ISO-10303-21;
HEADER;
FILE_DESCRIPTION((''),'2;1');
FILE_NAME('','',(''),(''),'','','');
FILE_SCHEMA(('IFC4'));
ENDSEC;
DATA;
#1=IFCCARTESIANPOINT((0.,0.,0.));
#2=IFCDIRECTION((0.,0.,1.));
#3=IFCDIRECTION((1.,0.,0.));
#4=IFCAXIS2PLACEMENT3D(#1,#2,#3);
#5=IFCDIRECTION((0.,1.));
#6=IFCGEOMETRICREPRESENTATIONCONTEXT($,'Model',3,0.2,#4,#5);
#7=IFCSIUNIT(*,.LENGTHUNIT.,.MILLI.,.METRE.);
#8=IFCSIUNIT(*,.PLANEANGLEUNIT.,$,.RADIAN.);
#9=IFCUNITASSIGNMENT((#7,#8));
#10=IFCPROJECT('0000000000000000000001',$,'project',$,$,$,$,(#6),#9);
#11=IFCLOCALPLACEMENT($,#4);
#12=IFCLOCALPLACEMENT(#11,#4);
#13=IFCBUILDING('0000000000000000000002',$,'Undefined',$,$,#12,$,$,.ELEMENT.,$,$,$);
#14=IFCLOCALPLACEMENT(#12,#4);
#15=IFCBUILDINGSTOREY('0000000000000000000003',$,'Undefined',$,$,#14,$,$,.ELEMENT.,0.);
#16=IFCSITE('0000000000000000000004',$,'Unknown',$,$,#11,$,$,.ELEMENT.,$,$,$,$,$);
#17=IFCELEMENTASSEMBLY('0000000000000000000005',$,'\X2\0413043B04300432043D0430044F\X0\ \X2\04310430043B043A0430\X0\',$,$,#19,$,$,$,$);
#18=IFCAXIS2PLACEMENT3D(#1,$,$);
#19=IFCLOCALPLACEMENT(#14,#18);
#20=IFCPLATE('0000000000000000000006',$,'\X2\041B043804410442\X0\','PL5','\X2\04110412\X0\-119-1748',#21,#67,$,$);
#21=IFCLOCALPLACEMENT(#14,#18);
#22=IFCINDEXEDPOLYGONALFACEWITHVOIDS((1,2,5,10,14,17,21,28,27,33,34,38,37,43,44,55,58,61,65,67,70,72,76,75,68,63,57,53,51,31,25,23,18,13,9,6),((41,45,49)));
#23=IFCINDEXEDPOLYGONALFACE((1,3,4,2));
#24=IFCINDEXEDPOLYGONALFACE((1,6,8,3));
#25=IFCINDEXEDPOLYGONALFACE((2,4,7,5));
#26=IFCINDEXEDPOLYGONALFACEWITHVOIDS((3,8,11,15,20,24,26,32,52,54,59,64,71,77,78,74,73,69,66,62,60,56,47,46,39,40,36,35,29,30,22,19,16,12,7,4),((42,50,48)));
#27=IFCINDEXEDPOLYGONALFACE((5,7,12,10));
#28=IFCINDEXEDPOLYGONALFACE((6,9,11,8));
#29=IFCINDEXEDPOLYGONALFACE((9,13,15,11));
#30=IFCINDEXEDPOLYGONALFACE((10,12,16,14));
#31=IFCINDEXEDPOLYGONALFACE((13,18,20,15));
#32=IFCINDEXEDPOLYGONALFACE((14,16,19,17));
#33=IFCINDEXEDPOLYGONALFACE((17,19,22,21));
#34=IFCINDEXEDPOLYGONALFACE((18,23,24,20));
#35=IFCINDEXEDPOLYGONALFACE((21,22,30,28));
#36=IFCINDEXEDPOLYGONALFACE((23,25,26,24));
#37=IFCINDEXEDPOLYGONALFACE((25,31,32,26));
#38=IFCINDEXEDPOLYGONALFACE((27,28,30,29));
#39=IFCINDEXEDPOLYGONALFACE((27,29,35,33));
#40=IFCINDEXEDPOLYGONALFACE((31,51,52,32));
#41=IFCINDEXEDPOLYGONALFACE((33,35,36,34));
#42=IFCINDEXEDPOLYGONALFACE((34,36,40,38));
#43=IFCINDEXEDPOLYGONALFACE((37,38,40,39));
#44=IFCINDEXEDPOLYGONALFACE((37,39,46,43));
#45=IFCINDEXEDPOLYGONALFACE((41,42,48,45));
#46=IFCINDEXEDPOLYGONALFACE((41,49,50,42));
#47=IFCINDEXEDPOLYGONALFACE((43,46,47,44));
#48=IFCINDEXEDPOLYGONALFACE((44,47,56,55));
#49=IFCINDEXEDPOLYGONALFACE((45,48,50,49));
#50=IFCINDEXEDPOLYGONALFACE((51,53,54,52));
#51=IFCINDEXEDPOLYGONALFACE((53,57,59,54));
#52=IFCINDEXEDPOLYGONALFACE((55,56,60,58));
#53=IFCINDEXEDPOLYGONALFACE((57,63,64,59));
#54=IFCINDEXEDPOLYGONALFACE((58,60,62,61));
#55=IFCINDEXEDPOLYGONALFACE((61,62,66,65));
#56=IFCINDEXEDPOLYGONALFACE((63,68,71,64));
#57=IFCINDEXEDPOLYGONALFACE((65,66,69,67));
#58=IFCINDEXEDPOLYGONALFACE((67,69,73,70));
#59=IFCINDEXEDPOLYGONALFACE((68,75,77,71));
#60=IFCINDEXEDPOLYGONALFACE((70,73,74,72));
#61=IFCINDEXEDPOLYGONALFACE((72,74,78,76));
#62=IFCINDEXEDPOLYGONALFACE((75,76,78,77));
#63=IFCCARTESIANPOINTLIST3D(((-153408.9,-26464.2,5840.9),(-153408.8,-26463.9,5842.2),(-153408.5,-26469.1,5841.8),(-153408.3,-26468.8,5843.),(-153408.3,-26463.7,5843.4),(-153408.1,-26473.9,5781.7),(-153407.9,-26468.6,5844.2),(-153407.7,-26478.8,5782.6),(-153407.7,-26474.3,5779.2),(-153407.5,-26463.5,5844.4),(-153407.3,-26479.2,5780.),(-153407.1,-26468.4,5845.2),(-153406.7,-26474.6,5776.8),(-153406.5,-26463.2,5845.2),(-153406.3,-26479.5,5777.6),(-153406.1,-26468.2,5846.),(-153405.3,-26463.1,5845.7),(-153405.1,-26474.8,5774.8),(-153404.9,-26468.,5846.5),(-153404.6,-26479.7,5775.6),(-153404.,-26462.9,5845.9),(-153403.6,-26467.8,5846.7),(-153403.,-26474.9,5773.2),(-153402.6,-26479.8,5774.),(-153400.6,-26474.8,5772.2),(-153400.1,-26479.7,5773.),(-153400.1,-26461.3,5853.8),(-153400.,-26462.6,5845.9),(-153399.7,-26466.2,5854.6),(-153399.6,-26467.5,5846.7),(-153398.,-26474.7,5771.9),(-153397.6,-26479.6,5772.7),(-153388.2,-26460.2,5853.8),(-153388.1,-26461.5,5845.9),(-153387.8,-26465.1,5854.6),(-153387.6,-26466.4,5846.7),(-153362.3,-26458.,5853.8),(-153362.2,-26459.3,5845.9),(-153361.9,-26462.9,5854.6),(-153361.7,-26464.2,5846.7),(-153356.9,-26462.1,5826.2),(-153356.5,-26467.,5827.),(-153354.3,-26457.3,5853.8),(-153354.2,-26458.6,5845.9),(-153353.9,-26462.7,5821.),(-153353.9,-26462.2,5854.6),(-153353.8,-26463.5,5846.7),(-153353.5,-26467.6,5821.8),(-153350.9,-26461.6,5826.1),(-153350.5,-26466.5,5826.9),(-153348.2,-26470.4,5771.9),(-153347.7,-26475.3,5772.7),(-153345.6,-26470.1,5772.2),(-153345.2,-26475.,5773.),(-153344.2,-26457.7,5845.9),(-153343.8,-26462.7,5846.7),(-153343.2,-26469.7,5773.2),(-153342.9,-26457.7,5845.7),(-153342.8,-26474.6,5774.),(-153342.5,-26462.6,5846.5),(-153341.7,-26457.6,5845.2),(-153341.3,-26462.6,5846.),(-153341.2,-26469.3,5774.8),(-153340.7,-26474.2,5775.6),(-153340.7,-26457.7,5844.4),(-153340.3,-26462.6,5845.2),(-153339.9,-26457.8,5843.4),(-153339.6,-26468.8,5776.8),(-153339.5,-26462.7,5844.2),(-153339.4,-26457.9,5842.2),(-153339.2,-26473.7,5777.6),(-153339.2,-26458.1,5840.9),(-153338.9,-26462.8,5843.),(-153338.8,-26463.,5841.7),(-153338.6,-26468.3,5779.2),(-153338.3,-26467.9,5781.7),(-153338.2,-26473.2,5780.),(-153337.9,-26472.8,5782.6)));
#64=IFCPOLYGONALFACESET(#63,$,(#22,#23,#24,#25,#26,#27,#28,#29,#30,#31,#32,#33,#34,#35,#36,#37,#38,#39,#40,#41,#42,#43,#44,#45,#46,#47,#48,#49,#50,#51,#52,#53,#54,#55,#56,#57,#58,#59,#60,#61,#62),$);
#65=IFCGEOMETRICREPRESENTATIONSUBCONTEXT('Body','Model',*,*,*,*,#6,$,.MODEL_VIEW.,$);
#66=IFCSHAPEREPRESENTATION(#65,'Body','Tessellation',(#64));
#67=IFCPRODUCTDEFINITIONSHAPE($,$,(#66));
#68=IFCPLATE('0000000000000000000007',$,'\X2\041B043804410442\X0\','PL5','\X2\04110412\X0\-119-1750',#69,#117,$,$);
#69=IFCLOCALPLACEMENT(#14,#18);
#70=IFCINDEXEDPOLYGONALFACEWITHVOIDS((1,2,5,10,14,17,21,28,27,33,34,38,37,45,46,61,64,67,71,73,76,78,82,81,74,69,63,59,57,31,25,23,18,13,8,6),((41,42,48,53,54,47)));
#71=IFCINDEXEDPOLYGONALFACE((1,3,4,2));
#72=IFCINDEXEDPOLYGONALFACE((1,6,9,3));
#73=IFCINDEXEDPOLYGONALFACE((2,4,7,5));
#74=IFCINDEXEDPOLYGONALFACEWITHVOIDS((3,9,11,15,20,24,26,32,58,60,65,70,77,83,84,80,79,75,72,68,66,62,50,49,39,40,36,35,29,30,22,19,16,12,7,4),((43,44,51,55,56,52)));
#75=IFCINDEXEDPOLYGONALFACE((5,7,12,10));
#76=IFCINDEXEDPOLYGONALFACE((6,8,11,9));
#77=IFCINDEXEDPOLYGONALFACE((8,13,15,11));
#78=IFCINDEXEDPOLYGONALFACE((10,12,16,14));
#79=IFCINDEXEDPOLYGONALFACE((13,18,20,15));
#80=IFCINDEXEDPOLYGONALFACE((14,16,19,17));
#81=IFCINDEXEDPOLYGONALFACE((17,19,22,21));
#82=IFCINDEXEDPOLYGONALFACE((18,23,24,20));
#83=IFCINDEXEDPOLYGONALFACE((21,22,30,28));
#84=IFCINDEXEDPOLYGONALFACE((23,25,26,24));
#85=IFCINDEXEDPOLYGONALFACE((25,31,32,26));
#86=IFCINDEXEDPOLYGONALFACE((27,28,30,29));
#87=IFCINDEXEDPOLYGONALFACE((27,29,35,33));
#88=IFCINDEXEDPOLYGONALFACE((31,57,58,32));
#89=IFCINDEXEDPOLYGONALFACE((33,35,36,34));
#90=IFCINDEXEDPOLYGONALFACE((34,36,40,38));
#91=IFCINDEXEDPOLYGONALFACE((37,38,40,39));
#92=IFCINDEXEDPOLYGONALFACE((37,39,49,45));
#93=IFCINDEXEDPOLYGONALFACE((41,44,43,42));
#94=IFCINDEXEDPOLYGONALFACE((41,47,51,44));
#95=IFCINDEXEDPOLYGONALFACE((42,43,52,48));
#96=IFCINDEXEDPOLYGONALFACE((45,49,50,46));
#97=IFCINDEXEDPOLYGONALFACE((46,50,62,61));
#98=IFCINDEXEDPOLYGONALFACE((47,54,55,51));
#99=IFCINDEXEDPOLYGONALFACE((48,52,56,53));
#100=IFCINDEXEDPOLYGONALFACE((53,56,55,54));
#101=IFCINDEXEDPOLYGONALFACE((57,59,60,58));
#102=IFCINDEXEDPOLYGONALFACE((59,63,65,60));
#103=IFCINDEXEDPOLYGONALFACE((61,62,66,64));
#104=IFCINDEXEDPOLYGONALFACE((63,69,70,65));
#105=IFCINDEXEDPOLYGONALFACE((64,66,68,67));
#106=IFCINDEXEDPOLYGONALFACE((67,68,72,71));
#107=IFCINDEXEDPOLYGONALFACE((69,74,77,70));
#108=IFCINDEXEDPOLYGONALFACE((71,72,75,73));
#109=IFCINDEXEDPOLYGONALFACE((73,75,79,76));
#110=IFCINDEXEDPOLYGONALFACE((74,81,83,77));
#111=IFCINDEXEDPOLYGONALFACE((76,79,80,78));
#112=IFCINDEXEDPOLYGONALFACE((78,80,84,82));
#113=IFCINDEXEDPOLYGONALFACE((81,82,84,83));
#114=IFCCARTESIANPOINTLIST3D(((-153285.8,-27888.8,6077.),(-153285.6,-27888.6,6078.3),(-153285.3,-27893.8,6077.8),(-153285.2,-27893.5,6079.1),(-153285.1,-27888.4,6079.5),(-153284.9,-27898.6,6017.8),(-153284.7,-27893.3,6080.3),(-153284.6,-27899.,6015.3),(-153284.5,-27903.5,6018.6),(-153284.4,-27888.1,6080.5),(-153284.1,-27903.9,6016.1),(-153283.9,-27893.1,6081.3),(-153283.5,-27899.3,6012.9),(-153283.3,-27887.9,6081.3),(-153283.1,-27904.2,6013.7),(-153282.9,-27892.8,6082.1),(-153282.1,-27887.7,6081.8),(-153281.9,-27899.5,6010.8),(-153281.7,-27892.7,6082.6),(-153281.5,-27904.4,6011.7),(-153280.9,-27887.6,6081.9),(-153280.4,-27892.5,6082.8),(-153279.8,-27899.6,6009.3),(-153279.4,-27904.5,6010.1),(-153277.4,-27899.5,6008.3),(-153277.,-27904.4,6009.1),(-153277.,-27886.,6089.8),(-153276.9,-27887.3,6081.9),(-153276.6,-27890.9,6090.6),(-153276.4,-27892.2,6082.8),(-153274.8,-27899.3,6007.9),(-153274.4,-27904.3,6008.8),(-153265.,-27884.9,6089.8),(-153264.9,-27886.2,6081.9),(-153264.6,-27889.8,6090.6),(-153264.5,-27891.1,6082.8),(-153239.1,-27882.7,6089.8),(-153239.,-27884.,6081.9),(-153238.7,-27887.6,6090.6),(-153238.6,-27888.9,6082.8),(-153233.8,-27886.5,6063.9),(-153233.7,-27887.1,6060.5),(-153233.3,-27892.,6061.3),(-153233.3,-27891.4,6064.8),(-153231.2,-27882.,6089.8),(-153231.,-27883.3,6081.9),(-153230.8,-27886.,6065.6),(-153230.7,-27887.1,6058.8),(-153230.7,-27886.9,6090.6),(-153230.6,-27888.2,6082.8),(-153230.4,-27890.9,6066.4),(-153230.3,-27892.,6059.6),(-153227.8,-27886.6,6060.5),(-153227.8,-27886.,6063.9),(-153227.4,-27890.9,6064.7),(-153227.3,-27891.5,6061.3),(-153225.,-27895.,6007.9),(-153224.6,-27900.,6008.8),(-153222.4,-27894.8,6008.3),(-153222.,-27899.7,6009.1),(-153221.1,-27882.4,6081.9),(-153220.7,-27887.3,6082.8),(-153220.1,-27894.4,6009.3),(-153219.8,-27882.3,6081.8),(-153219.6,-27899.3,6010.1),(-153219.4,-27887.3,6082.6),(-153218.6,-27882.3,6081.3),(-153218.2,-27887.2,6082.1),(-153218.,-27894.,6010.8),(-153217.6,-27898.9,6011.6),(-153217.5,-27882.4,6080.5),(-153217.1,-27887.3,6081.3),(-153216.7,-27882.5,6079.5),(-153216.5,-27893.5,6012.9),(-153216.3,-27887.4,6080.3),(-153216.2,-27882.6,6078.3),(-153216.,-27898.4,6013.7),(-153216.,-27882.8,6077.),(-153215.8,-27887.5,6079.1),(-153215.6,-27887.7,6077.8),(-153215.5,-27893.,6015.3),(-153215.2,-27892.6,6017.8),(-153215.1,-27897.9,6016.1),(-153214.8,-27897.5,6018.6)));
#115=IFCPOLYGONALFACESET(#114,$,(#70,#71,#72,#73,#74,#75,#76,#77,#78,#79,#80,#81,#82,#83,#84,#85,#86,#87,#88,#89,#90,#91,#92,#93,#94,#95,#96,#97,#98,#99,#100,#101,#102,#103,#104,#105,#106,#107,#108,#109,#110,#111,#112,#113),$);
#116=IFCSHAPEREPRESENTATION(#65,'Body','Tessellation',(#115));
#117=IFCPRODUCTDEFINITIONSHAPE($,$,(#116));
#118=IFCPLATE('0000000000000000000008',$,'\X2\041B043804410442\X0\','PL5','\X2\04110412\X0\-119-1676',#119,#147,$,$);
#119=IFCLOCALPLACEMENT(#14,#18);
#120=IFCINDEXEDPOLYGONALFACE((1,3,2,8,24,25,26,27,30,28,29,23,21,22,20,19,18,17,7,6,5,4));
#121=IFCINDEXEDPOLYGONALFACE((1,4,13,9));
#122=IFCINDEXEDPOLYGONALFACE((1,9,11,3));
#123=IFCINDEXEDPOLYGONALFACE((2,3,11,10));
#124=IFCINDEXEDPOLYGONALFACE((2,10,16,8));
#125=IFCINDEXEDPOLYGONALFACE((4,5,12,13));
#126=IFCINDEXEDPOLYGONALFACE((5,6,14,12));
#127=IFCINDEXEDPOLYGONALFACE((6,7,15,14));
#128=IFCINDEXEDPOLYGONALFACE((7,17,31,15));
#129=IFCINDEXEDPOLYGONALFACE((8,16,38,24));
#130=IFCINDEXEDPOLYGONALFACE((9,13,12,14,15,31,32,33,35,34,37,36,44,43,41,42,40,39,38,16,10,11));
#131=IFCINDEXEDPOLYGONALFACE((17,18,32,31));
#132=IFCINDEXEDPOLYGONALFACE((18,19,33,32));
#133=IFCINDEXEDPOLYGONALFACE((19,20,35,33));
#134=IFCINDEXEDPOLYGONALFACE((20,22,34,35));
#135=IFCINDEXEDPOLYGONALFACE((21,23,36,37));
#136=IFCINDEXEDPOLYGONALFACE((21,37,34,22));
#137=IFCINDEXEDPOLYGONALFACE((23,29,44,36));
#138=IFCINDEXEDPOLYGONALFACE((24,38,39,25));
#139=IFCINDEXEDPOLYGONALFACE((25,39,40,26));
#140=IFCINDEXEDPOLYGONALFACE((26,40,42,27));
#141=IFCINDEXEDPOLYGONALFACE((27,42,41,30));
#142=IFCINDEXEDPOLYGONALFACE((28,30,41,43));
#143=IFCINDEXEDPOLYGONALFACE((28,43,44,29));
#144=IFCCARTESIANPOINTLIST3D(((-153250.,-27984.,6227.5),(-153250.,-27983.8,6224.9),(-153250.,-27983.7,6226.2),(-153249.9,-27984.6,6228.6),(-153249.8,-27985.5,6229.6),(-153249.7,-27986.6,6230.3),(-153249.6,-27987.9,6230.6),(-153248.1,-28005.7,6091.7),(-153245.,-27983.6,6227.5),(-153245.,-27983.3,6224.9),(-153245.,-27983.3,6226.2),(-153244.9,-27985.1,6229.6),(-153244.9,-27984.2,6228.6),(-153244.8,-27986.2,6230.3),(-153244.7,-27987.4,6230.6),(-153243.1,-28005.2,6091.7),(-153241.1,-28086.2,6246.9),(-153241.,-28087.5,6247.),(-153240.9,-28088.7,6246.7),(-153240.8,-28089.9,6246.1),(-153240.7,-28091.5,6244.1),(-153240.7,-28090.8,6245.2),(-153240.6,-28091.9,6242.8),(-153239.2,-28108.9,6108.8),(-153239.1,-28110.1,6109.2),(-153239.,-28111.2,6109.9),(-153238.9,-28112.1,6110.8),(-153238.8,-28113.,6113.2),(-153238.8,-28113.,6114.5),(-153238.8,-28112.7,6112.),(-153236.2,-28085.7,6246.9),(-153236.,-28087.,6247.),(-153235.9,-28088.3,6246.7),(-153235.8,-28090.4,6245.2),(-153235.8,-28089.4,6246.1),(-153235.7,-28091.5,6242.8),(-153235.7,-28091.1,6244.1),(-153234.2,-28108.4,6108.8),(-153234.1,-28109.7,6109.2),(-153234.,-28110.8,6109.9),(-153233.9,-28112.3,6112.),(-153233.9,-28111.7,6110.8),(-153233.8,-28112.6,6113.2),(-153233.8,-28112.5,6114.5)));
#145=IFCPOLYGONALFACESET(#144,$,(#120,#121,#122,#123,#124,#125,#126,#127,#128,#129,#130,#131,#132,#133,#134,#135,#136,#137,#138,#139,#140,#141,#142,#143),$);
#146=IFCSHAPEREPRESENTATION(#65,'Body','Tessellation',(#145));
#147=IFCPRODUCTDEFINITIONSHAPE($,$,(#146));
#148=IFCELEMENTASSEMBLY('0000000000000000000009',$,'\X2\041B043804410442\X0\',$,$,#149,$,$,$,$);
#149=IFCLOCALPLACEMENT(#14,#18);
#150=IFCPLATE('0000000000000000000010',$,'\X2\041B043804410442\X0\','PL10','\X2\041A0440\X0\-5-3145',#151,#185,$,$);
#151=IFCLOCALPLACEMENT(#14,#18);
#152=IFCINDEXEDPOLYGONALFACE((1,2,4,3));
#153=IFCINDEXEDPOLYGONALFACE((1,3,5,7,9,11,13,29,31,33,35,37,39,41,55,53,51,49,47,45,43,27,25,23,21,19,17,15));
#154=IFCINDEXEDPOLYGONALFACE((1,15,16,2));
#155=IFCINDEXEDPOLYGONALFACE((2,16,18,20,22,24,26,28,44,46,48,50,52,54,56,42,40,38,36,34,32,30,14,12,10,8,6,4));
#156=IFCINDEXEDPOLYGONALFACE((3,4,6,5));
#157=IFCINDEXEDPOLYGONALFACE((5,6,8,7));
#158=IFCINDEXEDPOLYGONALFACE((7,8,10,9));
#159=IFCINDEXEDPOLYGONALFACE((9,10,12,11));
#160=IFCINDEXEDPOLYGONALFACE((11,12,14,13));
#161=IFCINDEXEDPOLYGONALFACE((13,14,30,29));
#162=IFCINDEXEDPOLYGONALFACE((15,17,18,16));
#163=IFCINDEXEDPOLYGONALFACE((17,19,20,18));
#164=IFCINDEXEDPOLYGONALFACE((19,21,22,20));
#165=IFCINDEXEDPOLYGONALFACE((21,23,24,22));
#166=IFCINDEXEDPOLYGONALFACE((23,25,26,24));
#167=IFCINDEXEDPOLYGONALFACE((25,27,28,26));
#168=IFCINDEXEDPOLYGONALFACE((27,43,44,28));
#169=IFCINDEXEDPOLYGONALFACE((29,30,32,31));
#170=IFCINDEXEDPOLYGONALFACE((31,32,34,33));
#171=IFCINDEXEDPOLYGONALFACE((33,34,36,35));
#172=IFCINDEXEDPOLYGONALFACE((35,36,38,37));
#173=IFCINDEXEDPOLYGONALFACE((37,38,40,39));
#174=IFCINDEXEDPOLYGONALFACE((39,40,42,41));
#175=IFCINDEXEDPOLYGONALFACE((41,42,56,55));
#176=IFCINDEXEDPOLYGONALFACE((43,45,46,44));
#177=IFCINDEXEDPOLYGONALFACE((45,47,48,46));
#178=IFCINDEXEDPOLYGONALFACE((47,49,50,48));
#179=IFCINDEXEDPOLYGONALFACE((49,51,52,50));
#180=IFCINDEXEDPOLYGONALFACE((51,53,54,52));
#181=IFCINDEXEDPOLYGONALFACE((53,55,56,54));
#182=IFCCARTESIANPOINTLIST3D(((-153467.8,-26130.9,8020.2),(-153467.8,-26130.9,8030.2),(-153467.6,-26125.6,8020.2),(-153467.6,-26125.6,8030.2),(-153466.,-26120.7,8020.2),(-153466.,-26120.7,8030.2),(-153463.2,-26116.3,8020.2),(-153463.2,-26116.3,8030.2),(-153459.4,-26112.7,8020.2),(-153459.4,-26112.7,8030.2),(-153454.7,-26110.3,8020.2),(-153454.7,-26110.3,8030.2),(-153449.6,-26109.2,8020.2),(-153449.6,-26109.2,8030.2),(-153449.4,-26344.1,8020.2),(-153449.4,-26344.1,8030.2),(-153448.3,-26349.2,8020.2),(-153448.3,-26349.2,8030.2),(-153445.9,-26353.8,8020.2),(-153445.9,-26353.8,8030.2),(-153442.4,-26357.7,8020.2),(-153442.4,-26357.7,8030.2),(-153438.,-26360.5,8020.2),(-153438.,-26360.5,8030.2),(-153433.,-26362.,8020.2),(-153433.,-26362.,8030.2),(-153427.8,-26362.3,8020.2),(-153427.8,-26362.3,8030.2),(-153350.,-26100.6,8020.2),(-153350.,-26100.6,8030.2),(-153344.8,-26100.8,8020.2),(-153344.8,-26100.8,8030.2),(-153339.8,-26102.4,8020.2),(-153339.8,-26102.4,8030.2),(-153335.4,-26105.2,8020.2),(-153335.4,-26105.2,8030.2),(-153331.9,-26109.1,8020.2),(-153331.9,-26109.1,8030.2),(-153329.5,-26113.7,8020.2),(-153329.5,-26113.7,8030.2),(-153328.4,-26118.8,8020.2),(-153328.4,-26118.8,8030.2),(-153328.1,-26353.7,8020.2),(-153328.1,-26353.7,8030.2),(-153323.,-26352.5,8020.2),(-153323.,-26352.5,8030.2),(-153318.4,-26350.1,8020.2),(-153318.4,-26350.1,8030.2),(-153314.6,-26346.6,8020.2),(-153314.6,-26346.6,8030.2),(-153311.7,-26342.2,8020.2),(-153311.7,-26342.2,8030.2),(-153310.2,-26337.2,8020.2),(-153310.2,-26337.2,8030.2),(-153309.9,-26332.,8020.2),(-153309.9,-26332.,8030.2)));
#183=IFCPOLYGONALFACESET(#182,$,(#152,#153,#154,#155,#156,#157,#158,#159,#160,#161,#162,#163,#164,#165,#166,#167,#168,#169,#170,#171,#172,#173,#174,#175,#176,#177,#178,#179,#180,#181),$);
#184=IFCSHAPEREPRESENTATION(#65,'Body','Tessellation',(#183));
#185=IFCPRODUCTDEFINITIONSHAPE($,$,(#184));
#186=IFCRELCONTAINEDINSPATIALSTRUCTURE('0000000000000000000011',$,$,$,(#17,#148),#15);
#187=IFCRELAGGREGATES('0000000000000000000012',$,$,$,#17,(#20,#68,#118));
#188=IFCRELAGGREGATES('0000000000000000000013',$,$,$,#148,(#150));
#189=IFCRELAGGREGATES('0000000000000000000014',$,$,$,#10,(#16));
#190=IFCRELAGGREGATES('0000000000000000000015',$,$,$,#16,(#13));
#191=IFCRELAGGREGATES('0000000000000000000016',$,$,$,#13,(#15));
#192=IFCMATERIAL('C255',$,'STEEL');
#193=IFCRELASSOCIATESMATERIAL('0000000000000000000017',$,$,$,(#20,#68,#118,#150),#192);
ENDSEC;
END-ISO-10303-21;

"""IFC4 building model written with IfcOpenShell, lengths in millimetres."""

from ifc_helpers import new_model, si_unit, direction, frame, origin_with_axes, place, context, subcontext, project, spatial, line, arc, indexed_curve, outline, extrude, material, element, aggregate, save


model = new_model("IFC4")

# Units and contexts
model_context = context("Model", 3, precision=0.2, world=origin_with_axes(), true_north=direction((0.0, 1.0)))
body_context = subcontext(model_context, "Body", "Model", "MODEL_VIEW")
ifc_project = project(units=[si_unit("LENGTHUNIT", "METRE", prefix="MILLI"), si_unit("PLANEANGLEUNIT", "RADIAN")], contexts=[model_context])

# Site, building, storey
site_placement = place(None, origin_with_axes())
site = spatial("IfcSite", under=ifc_project, at=site_placement, Name="Unknown", CompositionType="ELEMENT")
building_placement = place(site_placement, origin_with_axes())
building = spatial("IfcBuilding", under=site, at=building_placement, Name="Undefined", CompositionType="ELEMENT")
storey_placement = place(building_placement, origin_with_axes())
storey = spatial("IfcBuildingStorey", under=building, at=storey_placement, Name="Undefined", CompositionType="ELEMENT", Elevation=0.0)

# Shared definitions
ifc_material_1 = material(Name="C255", Category="STEEL")

# Element assembly, plates, voiding features
assembly_1_placement = place(storey_placement, frame((-153404.6, -26166.6, 5857.9), z_axis=(-0.996285, -0.086114, 0.000024), x_axis=(0.084961, -0.982981, 0.162881)))
assembly_1 = element("IfcElementAssembly", 1, at=assembly_1_placement, inside=storey, Name="Главная балка")
plate_1_placement = place(assembly_1_placement, frame((291.8, -135.0, -40.0), z_axis=(-1.0, -0.000054, 0.0), x_axis=(0.0, 0.000054, 1.0)))
plate_1 = element("IfcPlate", 2, at=plate_1_placement, material=ifc_material_1, Name="Лист", Description="PL5", ObjectType="БВ-119-1748", context=body_context, shape_type="SolidModel", body=[
    extrude(outline(indexed_curve([(0.0, 10.0), (2.9, 2.9), (10.0, 0.0), (60.0, 0.0), (67.1, 2.9), (70.0, 10.0), (70.0, 70.0), (68.5, 73.5), (65.0, 75.0), (61.0, 75.0), (61.0, 83.0), (49.0, 83.0), (49.0, 75.0), (23.0, 75.0), (23.0, 83.0), (15.0, 83.0), (15.0, 75.0), (5.0, 75.0), (1.5, 73.5), (0.0, 70.0)], segments=[arc(1, 2, 3), line(3, 4), arc(4, 5, 6), line(6, 7), arc(7, 8, 9), line(9, 10, 11, 12, 13, 14, 15, 16, 17, 18), arc(18, 19, 20), line(20, 1)])), frame((0.0, 0.0, 2.5), z_axis=(0.0, 0.0, 1.0), x_axis=(1.0, 0.0, 0.0)), (0.0, 0.0, -1.0), 5.0),
])
voiding_feature_1_placement = place(plate_1_placement, frame((15.0, 55.0, 10.0), z_axis=(0.007997, -0.999968, -0.000026), x_axis=(0.0, 0.000026, -1.0)))
element("IfcVoidingFeature", 3, at=voiding_feature_1_placement, cuts=plate_1, Name="Балка", ObjectType="(?)", PredefinedType="HOLE", context=body_context, shape_type="SolidModel", body=[
    extrude(outline(indexed_curve([(0.0, -3.0), (5.2, 0.0), (0.0, 3.0)], segments=[line(1, 2, 3, 1)])), frame((0.0, 0.0, 0.0), z_axis=(-1.0, 0.0, 0.0), x_axis=(0.0, 0.0, 1.0)), (0.0, 0.0, -1.0), 20.0),
])
plate_2_placement = place(assembly_1_placement, frame((1741.2, -135.0, -40.0), z_axis=(-1.0, -0.000054, 0.0), x_axis=(0.0, 0.000054, 1.0)))
plate_2 = element("IfcPlate", 4, at=plate_2_placement, material=ifc_material_1, Name="Лист", Description="PL5", ObjectType="БВ-119-1750", context=body_context, shape_type="SolidModel", body=[
    extrude(outline(indexed_curve([(0.0, 10.0), (2.9, 2.9), (10.0, 0.0), (60.0, 0.0), (67.1, 2.9), (70.0, 10.0), (70.0, 70.0), (68.5, 73.5), (65.0, 75.0), (61.0, 75.0), (61.0, 83.0), (49.0, 83.0), (49.0, 75.0), (23.0, 75.0), (23.0, 83.0), (15.0, 83.0), (15.0, 75.0), (5.0, 75.0), (1.5, 73.5), (0.0, 70.0)], segments=[arc(1, 2, 3), line(3, 4), arc(4, 5, 6), line(6, 7), arc(7, 8, 9), line(9, 10, 11, 12, 13, 14, 15, 16, 17, 18), arc(18, 19, 20), line(20, 1)])), frame((0.0, 0.0, 2.5), z_axis=(0.0, 0.0, 1.0), x_axis=(1.0, 0.0, 0.0)), (0.0, 0.0, -1.0), 5.0),
])
voiding_feature_2_placement = place(plate_2_placement, frame((15.0, 55.0, 10.0), z_axis=(0.007997, -0.999968, -0.000026), x_axis=(0.0, 0.000026, -1.0)))
element("IfcVoidingFeature", 5, at=voiding_feature_2_placement, cuts=plate_2, Name="Балка", ObjectType="(?)", PredefinedType="HOLE", context=body_context, shape_type="SolidModel", body=[
    extrude(outline(indexed_curve([(1.7, -3.0), (3.5, 0.0), (1.7, 3.0), (-1.7, 3.0), (-3.5, 0.0), (-1.7, -3.0)], segments=[line(1, 2, 3, 4, 5, 6, 1)])), frame((0.0, 0.0, 0.0), z_axis=(-1.0, 0.0, 0.0), x_axis=(0.0, 0.0, 1.0)), (0.0, 0.0, -1.0), 20.0),
])
plate_3_placement = place(assembly_1_placement, frame((1969.1, 70.0, 0.0), z_axis=(0.0, 0.0, -1.0), x_axis=(0.0, -1.0, 0.0)))
plate_3 = element("IfcPlate", 6, at=plate_3_placement, material=ifc_material_1, Name="Лист", Description="PL5", ObjectType="БВ-119-1676", context=body_context, shape_type="SolidModel", body=[
    extrude(outline(indexed_curve([(0.0, 5.0), (1.5, 1.5), (5.0, 0.0), (135.0, 0.0), (138.5, 1.5), (140.0, 5.0), (140.0, 110.0), (5.0, 110.0), (1.5, 108.5), (0.0, 105.0)], segments=[arc(1, 2, 3), line(3, 4), arc(4, 5, 6), line(6, 7, 8), arc(8, 9, 10), line(10, 1)])), frame((0.0, 0.0, 2.5), z_axis=(0.0, 0.0, 1.0), x_axis=(1.0, 0.0, 0.0)), (0.0, 0.0, -1.0), 5.0),
])
aggregate(assembly_1, [plate_1, plate_2, plate_3])

# Element assembly, plate
assembly_2_placement = place(storey_placement, frame((-153308.2, -26351.9, 8025.2), z_axis=(0.0, 0.0, 1.0), x_axis=(-0.086114, 0.996285, 0.0)))
assembly_2 = element("IfcElementAssembly", 7, at=assembly_2_placement, inside=storey, Name="Лист")
plate_4_placement = place(assembly_2_placement, origin_with_axes())
plate_4 = element("IfcPlate", 8, at=plate_4_placement, material=ifc_material_1, Name="Лист", Description="PL10", ObjectType="Кр-5-3145", context=body_context, shape_type="SolidModel", body=[
    extrude(outline(indexed_curve([(0.0, 20.0), (5.9, 5.9), (20.0, 0.0), (234.0, 0.0), (248.1, 5.9), (254.0, 20.0), (254.0, 120.0), (248.1, 134.1), (234.0, 140.0), (20.0, 140.0), (5.9, 134.1), (0.0, 120.0)], segments=[arc(1, 2, 3), line(3, 4), arc(4, 5, 6), line(6, 7), arc(7, 8, 9), line(9, 10), arc(10, 11, 12), line(12, 1)])), frame((0.0, 0.0, 5.0), z_axis=(0.0, 0.0, 1.0), x_axis=(1.0, 0.0, 0.0)), (0.0, 0.0, -1.0), 10.0),
])
aggregate(assembly_2, [plate_4])

save(model, "model.ifc")
